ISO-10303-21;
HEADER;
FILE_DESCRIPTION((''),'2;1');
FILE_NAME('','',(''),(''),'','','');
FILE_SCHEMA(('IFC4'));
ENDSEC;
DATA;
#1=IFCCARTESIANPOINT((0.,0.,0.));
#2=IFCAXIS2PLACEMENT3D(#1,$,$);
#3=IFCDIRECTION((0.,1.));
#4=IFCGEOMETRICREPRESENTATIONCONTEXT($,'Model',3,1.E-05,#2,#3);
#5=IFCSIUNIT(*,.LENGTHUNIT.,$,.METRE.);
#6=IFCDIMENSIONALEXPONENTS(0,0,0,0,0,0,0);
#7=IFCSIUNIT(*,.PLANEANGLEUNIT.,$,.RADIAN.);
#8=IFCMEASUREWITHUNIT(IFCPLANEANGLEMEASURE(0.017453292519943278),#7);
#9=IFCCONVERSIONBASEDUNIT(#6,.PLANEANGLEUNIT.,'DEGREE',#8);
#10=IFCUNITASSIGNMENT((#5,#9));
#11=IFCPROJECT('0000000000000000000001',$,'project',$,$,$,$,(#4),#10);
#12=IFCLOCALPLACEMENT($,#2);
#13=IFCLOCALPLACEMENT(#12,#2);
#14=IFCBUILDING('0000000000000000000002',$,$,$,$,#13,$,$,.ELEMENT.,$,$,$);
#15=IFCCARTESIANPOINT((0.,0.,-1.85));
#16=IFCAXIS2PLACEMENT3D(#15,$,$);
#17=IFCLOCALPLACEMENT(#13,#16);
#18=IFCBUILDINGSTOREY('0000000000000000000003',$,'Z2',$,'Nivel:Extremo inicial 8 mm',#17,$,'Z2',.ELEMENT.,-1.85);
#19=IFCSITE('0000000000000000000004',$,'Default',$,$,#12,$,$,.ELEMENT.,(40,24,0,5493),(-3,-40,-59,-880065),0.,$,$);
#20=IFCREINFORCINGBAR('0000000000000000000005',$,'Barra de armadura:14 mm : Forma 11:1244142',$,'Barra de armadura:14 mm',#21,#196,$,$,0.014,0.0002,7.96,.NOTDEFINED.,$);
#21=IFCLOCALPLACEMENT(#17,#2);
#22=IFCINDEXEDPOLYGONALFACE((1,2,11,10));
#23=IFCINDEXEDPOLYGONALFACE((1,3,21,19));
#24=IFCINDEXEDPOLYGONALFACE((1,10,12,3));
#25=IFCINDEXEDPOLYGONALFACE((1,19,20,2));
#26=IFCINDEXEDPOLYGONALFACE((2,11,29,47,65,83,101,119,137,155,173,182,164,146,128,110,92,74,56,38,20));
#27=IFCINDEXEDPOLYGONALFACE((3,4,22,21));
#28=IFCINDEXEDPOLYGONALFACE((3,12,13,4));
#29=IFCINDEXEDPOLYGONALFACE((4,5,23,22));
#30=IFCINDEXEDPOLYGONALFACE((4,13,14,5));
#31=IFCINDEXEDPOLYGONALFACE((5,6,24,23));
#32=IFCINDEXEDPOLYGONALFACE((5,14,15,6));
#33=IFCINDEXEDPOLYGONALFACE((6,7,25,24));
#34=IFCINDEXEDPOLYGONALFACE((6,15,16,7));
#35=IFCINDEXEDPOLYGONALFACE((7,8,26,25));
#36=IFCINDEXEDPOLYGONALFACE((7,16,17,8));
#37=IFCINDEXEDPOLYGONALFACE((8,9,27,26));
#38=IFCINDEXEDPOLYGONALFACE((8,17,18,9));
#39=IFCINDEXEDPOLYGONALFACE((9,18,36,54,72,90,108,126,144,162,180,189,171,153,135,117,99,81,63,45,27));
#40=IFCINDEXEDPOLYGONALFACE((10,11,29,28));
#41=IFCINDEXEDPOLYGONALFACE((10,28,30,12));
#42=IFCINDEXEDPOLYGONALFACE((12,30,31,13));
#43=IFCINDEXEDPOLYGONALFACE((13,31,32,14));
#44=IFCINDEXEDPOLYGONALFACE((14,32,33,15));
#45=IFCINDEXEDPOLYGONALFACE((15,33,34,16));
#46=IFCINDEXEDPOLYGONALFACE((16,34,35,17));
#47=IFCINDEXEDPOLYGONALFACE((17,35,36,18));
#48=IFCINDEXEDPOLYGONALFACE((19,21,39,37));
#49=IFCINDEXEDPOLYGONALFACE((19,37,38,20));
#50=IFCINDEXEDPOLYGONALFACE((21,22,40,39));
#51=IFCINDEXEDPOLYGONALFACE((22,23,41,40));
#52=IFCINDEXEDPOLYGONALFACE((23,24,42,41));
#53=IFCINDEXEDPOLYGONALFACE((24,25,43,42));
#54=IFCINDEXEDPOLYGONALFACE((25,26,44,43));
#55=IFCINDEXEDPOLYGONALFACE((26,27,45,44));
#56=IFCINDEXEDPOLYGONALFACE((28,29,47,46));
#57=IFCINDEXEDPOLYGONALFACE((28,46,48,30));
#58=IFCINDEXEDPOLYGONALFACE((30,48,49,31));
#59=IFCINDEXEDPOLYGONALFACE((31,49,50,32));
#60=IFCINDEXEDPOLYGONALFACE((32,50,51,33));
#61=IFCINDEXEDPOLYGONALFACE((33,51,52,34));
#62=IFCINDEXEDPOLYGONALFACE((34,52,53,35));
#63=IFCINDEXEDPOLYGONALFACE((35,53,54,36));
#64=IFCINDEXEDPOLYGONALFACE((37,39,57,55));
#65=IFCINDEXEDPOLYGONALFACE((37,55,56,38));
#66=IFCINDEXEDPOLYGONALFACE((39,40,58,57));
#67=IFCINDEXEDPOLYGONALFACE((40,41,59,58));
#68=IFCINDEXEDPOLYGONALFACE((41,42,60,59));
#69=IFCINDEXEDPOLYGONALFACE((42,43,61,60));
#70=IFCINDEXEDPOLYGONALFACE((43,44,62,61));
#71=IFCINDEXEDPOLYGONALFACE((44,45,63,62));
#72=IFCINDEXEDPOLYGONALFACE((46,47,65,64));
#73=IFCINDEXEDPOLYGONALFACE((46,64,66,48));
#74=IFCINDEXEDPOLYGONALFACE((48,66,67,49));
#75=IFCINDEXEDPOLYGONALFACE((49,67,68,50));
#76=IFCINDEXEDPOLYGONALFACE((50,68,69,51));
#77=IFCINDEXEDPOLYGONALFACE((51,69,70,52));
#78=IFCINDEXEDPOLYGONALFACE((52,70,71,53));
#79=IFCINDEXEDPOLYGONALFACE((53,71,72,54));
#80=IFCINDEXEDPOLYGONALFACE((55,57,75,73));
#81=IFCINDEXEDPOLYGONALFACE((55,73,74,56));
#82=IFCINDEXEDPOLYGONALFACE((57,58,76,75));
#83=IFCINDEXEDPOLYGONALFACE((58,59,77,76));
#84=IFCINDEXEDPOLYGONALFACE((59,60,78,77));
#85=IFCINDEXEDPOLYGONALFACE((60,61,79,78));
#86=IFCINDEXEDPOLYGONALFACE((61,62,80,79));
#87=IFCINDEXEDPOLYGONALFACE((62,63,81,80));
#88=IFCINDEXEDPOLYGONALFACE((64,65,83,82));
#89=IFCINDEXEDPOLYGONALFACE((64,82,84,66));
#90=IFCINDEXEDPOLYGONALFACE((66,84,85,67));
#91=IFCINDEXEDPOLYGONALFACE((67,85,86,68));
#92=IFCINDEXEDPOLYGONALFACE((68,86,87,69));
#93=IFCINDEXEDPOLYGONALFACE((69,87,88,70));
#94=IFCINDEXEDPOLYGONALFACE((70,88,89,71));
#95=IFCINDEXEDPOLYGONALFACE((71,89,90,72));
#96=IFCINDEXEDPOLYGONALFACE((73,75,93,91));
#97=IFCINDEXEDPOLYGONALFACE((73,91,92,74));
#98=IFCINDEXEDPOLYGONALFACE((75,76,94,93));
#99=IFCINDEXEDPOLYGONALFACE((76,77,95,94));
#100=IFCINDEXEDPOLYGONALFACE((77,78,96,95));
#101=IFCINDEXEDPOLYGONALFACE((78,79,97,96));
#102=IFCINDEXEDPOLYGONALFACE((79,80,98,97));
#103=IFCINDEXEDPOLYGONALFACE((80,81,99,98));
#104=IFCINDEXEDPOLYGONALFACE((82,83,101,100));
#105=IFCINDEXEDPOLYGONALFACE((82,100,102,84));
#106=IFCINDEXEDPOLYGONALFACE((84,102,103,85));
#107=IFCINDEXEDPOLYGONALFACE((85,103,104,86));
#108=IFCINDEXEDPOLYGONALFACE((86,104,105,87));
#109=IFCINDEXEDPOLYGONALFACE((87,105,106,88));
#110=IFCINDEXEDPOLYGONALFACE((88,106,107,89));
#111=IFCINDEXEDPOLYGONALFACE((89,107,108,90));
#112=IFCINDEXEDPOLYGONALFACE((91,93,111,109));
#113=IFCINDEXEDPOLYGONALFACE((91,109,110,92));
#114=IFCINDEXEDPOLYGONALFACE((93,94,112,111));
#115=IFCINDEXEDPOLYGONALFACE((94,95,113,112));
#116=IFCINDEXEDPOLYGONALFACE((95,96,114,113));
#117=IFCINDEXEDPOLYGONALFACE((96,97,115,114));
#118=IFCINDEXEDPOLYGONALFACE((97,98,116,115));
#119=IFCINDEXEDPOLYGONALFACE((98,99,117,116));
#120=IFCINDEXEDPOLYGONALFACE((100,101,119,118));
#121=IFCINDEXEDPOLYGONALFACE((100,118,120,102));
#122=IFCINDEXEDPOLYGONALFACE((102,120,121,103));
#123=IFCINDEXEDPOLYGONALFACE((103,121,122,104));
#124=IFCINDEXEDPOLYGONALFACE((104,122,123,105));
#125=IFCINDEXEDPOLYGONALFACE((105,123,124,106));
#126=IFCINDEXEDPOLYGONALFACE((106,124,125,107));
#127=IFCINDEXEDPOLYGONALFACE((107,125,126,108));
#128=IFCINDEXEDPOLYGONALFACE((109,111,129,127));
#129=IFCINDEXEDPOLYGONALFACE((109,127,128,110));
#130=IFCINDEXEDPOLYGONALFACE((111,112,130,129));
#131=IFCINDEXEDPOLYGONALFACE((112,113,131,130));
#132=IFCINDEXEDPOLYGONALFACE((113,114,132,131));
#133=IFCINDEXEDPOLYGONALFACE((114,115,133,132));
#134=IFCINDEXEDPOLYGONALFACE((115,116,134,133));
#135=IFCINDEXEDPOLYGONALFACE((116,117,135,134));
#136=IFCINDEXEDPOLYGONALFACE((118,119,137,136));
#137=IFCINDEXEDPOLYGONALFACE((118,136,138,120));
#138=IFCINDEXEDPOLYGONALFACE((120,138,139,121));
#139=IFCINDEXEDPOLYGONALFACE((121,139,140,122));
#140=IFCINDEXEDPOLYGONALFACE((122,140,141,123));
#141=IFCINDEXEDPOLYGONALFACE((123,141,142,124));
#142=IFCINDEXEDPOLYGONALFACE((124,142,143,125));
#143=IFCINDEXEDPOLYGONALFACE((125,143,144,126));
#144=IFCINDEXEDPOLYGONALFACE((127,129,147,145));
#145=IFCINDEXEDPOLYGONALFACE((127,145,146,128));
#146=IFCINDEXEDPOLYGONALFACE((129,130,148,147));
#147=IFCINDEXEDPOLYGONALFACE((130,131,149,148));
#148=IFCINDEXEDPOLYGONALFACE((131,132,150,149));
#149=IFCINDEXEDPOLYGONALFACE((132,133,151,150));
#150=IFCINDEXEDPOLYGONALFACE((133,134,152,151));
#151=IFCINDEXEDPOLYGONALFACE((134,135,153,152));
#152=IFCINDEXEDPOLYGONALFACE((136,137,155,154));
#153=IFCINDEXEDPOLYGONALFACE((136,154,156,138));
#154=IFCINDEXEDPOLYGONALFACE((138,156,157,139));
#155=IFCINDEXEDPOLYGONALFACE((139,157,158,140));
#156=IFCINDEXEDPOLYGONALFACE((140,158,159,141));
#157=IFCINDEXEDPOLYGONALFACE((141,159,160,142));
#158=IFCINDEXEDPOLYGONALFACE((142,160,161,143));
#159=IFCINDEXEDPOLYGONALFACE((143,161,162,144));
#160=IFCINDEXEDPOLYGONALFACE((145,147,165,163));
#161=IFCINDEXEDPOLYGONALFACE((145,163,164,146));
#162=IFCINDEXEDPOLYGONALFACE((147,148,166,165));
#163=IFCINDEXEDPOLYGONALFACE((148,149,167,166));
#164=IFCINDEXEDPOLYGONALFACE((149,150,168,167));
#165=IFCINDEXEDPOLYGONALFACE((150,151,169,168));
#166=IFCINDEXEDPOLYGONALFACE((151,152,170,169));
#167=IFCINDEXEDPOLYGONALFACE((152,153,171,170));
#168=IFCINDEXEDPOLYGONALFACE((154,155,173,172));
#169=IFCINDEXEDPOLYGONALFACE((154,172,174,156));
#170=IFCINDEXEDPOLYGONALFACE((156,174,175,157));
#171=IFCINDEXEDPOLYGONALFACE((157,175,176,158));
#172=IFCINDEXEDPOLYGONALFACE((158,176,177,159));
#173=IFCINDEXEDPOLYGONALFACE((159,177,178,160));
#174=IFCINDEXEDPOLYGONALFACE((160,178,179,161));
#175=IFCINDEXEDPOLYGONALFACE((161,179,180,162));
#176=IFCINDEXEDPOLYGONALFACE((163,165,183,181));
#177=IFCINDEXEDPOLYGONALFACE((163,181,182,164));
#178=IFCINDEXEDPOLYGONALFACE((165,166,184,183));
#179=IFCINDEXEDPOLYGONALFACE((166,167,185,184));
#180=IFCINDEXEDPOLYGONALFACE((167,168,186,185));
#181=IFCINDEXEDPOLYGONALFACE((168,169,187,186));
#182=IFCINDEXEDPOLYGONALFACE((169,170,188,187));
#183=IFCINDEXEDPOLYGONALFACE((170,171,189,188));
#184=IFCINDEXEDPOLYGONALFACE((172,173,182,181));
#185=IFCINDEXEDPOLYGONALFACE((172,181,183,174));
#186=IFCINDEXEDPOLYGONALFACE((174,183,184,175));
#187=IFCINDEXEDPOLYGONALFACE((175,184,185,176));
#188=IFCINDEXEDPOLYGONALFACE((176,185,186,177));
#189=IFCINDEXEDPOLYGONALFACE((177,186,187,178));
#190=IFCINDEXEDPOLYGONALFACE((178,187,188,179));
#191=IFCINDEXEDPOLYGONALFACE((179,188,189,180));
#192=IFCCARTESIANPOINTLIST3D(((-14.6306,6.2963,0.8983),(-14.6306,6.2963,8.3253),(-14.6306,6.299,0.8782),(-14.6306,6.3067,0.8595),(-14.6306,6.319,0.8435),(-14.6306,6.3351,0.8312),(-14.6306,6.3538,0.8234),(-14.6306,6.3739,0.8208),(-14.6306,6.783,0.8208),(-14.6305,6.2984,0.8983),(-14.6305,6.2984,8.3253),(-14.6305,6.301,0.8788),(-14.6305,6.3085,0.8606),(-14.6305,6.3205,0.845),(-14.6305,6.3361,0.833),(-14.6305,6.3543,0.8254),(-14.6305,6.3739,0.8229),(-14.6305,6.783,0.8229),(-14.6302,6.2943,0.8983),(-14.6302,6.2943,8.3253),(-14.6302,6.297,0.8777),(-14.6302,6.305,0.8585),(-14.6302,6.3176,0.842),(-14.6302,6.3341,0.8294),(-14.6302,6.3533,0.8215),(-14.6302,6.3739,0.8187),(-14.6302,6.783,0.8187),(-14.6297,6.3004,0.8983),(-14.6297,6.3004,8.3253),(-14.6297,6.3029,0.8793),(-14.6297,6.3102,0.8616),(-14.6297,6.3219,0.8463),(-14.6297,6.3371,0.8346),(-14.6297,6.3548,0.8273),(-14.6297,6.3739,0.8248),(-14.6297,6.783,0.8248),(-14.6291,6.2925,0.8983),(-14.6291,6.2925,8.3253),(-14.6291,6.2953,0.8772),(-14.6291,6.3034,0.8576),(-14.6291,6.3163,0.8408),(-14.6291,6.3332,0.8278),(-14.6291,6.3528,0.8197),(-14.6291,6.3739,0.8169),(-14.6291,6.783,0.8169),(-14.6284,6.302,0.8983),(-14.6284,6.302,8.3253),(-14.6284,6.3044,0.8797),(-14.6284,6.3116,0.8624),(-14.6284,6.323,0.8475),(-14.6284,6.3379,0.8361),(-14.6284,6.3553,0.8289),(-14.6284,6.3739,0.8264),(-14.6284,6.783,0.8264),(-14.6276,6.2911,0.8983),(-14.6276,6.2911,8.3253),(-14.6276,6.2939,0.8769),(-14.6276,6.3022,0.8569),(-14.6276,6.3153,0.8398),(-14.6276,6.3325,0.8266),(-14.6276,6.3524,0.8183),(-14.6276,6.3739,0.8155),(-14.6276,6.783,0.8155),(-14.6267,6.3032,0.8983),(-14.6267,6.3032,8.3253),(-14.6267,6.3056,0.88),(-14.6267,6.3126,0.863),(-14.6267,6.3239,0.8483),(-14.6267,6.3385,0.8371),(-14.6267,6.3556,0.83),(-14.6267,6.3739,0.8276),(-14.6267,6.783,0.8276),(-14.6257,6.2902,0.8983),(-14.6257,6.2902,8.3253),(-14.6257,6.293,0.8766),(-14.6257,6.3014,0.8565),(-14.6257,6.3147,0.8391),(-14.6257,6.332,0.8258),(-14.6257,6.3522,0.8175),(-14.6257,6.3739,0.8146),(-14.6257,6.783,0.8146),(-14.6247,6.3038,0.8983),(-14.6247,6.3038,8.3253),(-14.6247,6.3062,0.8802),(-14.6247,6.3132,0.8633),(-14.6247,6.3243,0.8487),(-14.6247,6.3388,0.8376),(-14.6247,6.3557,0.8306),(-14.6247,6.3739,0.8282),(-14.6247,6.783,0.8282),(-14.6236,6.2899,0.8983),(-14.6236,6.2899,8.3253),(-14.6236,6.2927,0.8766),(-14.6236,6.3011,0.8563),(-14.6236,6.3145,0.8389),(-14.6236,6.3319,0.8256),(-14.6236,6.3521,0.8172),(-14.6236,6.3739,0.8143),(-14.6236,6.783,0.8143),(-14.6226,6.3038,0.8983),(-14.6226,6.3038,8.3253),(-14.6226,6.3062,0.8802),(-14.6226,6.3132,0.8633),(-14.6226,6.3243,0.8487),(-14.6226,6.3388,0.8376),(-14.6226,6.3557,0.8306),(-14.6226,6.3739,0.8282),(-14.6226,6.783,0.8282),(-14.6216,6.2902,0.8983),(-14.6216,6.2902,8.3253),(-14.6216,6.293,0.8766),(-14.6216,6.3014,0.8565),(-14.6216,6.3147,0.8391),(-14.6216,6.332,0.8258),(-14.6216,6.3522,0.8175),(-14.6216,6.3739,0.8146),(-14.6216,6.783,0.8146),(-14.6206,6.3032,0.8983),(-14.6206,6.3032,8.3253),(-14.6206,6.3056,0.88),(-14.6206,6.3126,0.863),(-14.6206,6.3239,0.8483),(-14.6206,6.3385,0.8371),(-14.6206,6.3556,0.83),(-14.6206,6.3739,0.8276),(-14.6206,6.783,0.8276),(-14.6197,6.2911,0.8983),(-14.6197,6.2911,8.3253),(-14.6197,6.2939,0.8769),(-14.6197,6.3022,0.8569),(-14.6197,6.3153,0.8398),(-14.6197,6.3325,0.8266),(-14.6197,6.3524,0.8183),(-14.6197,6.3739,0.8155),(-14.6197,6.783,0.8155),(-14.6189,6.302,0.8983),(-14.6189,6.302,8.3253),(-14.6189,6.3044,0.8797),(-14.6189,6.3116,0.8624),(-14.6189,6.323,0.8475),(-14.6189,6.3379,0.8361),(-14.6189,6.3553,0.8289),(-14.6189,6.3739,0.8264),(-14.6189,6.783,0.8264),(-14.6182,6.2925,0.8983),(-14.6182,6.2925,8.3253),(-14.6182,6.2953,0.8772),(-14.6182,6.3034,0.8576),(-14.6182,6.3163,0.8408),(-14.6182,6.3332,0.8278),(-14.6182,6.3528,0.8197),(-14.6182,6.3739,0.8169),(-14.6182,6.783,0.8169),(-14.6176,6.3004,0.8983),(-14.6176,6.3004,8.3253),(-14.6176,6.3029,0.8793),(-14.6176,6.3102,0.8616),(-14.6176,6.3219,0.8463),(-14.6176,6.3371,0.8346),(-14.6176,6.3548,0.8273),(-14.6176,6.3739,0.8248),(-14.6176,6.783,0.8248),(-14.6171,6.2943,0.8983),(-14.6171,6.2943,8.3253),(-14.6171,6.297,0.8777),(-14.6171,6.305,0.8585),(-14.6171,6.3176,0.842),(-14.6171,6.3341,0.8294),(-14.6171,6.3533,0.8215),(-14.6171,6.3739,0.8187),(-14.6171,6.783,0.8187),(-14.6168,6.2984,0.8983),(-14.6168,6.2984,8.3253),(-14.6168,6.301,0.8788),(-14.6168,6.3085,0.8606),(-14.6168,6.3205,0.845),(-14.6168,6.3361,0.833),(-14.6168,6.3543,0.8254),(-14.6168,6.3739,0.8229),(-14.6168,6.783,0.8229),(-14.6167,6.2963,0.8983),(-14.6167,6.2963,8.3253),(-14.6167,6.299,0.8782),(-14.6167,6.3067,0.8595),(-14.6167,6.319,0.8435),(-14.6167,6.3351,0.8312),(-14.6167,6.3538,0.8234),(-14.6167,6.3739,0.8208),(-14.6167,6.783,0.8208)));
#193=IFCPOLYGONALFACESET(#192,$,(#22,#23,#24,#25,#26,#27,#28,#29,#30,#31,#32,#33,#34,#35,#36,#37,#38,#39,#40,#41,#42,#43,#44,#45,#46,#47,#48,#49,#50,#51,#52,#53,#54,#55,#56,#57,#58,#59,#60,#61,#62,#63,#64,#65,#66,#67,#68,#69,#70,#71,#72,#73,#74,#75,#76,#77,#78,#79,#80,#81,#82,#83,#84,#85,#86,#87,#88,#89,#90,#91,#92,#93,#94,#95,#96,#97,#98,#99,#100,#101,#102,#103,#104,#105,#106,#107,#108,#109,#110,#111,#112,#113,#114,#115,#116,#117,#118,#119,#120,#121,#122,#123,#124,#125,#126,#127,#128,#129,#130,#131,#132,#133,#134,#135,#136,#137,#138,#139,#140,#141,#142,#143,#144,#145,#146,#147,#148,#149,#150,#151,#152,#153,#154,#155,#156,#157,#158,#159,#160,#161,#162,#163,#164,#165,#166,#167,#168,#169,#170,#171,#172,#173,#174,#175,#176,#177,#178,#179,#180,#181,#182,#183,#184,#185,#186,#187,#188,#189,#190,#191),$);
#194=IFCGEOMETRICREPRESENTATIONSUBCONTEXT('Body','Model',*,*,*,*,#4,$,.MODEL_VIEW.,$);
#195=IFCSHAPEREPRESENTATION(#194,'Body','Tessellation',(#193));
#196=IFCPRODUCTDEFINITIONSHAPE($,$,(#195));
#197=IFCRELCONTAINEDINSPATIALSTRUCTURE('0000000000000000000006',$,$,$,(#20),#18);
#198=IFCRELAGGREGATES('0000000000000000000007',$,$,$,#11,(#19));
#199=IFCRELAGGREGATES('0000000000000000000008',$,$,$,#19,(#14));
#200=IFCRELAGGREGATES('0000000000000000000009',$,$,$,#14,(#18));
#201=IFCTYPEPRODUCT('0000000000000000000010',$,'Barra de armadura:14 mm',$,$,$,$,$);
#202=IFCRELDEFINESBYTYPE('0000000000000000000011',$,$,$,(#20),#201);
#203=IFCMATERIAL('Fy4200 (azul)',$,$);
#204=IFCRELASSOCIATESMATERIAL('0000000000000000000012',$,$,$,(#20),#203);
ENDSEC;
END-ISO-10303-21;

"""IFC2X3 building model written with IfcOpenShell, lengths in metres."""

from ifc_helpers import new_model, entity, si_unit, converted_unit, direction, frame, origin, place, context, subcontext, project, spatial, material, type_object, element, save


model = new_model("IFC2X3")

# Units and contexts
model_context = context("Model", 3, precision=1e-05, world=origin(), true_north=direction((0.0, 1.0)))
body_context = subcontext(model_context, "Body", "Model", "MODEL_VIEW")
ifc_project = project(units=[si_unit("LENGTHUNIT", "METRE"), converted_unit("PLANEANGLEUNIT", "DEGREE", entity("IfcPlaneAngleMeasure", 0.017453292519943278), si_unit("PLANEANGLEUNIT", "RADIAN"), dimensions=[0, 0, 0, 0, 0, 0, 0])], contexts=[model_context])

# Site, building, storey
site_placement = place(None, origin())
site = spatial("IfcSite", under=ifc_project, at=site_placement, Name="Default", CompositionType="ELEMENT", RefLatitude=(40, 24, 0, 5493), RefLongitude=(-3, -40, -59, -880065), RefElevation=0.0)
building_placement = place(site_placement, origin())
building = spatial("IfcBuilding", under=site, at=building_placement, CompositionType="ELEMENT")
storey_placement = place(building_placement, frame((0.0, 0.0, -1.85)))
storey = spatial("IfcBuildingStorey", under=building, at=storey_placement, Name="Z2", ObjectType="Nivel:Extremo inicial 8 mm", LongName="Z2", CompositionType="ELEMENT", Elevation=-1.85)

# Reinforcing bar
ifc_material_1 = material(Name="Fy4200 (azul)")
type_product_1 = type_object("IfcTypeProduct", Name="Barra de armadura:14 mm")
reinforcing_bar_1_placement = place(storey_placement, origin())
element("IfcReinforcingBar", 1, at=reinforcing_bar_1_placement, inside=storey, type_object=type_product_1, material=ifc_material_1, Name="Barra de armadura:14 mm : Forma 11:1244142", ObjectType="Barra de armadura:14 mm", BarLength=7.96, BarRole="NOTDEFINED", CrossSectionArea=0.0002, NominalDiameter=0.014, context=body_context, shape_type="AdvancedSweptSolid", body=[
    entity("IfcSweptDiskSolid", entity("IfcCompositeCurve", [entity("IfcCompositeCurveSegment", "CONTINUOUS", True, entity("IfcPolyline", [entity("IfcCartesianPoint", [-14.6236, 6.2969, 8.3253]), entity("IfcCartesianPoint", [-14.6236, 6.2969, 0.8983])])), entity("IfcCompositeCurveSegment", "CONTINUOUS", True, entity("IfcTrimmedCurve", entity("IfcCircle", entity("IfcAxis2Placement3D", entity("IfcCartesianPoint", [-14.6236, 6.3739, 0.8983]), entity("IfcDirection", [1.0, 0.0, 0.0]), entity("IfcDirection", [0.0, 0.0, -1.0])), 0.077), [entity("IfcParameterValue", 270.0)], [entity("IfcParameterValue", 360.0)], True, "PARAMETER")), entity("IfcCompositeCurveSegment", "CONTINUOUS", True, entity("IfcPolyline", [entity("IfcCartesianPoint", [-14.6236, 6.3739, 0.8213]), entity("IfcCartesianPoint", [-14.6236, 6.783, 0.8213])]))], False), 0.007, None, 0.0, 92.0),
])

save(model, "model.ifc")
